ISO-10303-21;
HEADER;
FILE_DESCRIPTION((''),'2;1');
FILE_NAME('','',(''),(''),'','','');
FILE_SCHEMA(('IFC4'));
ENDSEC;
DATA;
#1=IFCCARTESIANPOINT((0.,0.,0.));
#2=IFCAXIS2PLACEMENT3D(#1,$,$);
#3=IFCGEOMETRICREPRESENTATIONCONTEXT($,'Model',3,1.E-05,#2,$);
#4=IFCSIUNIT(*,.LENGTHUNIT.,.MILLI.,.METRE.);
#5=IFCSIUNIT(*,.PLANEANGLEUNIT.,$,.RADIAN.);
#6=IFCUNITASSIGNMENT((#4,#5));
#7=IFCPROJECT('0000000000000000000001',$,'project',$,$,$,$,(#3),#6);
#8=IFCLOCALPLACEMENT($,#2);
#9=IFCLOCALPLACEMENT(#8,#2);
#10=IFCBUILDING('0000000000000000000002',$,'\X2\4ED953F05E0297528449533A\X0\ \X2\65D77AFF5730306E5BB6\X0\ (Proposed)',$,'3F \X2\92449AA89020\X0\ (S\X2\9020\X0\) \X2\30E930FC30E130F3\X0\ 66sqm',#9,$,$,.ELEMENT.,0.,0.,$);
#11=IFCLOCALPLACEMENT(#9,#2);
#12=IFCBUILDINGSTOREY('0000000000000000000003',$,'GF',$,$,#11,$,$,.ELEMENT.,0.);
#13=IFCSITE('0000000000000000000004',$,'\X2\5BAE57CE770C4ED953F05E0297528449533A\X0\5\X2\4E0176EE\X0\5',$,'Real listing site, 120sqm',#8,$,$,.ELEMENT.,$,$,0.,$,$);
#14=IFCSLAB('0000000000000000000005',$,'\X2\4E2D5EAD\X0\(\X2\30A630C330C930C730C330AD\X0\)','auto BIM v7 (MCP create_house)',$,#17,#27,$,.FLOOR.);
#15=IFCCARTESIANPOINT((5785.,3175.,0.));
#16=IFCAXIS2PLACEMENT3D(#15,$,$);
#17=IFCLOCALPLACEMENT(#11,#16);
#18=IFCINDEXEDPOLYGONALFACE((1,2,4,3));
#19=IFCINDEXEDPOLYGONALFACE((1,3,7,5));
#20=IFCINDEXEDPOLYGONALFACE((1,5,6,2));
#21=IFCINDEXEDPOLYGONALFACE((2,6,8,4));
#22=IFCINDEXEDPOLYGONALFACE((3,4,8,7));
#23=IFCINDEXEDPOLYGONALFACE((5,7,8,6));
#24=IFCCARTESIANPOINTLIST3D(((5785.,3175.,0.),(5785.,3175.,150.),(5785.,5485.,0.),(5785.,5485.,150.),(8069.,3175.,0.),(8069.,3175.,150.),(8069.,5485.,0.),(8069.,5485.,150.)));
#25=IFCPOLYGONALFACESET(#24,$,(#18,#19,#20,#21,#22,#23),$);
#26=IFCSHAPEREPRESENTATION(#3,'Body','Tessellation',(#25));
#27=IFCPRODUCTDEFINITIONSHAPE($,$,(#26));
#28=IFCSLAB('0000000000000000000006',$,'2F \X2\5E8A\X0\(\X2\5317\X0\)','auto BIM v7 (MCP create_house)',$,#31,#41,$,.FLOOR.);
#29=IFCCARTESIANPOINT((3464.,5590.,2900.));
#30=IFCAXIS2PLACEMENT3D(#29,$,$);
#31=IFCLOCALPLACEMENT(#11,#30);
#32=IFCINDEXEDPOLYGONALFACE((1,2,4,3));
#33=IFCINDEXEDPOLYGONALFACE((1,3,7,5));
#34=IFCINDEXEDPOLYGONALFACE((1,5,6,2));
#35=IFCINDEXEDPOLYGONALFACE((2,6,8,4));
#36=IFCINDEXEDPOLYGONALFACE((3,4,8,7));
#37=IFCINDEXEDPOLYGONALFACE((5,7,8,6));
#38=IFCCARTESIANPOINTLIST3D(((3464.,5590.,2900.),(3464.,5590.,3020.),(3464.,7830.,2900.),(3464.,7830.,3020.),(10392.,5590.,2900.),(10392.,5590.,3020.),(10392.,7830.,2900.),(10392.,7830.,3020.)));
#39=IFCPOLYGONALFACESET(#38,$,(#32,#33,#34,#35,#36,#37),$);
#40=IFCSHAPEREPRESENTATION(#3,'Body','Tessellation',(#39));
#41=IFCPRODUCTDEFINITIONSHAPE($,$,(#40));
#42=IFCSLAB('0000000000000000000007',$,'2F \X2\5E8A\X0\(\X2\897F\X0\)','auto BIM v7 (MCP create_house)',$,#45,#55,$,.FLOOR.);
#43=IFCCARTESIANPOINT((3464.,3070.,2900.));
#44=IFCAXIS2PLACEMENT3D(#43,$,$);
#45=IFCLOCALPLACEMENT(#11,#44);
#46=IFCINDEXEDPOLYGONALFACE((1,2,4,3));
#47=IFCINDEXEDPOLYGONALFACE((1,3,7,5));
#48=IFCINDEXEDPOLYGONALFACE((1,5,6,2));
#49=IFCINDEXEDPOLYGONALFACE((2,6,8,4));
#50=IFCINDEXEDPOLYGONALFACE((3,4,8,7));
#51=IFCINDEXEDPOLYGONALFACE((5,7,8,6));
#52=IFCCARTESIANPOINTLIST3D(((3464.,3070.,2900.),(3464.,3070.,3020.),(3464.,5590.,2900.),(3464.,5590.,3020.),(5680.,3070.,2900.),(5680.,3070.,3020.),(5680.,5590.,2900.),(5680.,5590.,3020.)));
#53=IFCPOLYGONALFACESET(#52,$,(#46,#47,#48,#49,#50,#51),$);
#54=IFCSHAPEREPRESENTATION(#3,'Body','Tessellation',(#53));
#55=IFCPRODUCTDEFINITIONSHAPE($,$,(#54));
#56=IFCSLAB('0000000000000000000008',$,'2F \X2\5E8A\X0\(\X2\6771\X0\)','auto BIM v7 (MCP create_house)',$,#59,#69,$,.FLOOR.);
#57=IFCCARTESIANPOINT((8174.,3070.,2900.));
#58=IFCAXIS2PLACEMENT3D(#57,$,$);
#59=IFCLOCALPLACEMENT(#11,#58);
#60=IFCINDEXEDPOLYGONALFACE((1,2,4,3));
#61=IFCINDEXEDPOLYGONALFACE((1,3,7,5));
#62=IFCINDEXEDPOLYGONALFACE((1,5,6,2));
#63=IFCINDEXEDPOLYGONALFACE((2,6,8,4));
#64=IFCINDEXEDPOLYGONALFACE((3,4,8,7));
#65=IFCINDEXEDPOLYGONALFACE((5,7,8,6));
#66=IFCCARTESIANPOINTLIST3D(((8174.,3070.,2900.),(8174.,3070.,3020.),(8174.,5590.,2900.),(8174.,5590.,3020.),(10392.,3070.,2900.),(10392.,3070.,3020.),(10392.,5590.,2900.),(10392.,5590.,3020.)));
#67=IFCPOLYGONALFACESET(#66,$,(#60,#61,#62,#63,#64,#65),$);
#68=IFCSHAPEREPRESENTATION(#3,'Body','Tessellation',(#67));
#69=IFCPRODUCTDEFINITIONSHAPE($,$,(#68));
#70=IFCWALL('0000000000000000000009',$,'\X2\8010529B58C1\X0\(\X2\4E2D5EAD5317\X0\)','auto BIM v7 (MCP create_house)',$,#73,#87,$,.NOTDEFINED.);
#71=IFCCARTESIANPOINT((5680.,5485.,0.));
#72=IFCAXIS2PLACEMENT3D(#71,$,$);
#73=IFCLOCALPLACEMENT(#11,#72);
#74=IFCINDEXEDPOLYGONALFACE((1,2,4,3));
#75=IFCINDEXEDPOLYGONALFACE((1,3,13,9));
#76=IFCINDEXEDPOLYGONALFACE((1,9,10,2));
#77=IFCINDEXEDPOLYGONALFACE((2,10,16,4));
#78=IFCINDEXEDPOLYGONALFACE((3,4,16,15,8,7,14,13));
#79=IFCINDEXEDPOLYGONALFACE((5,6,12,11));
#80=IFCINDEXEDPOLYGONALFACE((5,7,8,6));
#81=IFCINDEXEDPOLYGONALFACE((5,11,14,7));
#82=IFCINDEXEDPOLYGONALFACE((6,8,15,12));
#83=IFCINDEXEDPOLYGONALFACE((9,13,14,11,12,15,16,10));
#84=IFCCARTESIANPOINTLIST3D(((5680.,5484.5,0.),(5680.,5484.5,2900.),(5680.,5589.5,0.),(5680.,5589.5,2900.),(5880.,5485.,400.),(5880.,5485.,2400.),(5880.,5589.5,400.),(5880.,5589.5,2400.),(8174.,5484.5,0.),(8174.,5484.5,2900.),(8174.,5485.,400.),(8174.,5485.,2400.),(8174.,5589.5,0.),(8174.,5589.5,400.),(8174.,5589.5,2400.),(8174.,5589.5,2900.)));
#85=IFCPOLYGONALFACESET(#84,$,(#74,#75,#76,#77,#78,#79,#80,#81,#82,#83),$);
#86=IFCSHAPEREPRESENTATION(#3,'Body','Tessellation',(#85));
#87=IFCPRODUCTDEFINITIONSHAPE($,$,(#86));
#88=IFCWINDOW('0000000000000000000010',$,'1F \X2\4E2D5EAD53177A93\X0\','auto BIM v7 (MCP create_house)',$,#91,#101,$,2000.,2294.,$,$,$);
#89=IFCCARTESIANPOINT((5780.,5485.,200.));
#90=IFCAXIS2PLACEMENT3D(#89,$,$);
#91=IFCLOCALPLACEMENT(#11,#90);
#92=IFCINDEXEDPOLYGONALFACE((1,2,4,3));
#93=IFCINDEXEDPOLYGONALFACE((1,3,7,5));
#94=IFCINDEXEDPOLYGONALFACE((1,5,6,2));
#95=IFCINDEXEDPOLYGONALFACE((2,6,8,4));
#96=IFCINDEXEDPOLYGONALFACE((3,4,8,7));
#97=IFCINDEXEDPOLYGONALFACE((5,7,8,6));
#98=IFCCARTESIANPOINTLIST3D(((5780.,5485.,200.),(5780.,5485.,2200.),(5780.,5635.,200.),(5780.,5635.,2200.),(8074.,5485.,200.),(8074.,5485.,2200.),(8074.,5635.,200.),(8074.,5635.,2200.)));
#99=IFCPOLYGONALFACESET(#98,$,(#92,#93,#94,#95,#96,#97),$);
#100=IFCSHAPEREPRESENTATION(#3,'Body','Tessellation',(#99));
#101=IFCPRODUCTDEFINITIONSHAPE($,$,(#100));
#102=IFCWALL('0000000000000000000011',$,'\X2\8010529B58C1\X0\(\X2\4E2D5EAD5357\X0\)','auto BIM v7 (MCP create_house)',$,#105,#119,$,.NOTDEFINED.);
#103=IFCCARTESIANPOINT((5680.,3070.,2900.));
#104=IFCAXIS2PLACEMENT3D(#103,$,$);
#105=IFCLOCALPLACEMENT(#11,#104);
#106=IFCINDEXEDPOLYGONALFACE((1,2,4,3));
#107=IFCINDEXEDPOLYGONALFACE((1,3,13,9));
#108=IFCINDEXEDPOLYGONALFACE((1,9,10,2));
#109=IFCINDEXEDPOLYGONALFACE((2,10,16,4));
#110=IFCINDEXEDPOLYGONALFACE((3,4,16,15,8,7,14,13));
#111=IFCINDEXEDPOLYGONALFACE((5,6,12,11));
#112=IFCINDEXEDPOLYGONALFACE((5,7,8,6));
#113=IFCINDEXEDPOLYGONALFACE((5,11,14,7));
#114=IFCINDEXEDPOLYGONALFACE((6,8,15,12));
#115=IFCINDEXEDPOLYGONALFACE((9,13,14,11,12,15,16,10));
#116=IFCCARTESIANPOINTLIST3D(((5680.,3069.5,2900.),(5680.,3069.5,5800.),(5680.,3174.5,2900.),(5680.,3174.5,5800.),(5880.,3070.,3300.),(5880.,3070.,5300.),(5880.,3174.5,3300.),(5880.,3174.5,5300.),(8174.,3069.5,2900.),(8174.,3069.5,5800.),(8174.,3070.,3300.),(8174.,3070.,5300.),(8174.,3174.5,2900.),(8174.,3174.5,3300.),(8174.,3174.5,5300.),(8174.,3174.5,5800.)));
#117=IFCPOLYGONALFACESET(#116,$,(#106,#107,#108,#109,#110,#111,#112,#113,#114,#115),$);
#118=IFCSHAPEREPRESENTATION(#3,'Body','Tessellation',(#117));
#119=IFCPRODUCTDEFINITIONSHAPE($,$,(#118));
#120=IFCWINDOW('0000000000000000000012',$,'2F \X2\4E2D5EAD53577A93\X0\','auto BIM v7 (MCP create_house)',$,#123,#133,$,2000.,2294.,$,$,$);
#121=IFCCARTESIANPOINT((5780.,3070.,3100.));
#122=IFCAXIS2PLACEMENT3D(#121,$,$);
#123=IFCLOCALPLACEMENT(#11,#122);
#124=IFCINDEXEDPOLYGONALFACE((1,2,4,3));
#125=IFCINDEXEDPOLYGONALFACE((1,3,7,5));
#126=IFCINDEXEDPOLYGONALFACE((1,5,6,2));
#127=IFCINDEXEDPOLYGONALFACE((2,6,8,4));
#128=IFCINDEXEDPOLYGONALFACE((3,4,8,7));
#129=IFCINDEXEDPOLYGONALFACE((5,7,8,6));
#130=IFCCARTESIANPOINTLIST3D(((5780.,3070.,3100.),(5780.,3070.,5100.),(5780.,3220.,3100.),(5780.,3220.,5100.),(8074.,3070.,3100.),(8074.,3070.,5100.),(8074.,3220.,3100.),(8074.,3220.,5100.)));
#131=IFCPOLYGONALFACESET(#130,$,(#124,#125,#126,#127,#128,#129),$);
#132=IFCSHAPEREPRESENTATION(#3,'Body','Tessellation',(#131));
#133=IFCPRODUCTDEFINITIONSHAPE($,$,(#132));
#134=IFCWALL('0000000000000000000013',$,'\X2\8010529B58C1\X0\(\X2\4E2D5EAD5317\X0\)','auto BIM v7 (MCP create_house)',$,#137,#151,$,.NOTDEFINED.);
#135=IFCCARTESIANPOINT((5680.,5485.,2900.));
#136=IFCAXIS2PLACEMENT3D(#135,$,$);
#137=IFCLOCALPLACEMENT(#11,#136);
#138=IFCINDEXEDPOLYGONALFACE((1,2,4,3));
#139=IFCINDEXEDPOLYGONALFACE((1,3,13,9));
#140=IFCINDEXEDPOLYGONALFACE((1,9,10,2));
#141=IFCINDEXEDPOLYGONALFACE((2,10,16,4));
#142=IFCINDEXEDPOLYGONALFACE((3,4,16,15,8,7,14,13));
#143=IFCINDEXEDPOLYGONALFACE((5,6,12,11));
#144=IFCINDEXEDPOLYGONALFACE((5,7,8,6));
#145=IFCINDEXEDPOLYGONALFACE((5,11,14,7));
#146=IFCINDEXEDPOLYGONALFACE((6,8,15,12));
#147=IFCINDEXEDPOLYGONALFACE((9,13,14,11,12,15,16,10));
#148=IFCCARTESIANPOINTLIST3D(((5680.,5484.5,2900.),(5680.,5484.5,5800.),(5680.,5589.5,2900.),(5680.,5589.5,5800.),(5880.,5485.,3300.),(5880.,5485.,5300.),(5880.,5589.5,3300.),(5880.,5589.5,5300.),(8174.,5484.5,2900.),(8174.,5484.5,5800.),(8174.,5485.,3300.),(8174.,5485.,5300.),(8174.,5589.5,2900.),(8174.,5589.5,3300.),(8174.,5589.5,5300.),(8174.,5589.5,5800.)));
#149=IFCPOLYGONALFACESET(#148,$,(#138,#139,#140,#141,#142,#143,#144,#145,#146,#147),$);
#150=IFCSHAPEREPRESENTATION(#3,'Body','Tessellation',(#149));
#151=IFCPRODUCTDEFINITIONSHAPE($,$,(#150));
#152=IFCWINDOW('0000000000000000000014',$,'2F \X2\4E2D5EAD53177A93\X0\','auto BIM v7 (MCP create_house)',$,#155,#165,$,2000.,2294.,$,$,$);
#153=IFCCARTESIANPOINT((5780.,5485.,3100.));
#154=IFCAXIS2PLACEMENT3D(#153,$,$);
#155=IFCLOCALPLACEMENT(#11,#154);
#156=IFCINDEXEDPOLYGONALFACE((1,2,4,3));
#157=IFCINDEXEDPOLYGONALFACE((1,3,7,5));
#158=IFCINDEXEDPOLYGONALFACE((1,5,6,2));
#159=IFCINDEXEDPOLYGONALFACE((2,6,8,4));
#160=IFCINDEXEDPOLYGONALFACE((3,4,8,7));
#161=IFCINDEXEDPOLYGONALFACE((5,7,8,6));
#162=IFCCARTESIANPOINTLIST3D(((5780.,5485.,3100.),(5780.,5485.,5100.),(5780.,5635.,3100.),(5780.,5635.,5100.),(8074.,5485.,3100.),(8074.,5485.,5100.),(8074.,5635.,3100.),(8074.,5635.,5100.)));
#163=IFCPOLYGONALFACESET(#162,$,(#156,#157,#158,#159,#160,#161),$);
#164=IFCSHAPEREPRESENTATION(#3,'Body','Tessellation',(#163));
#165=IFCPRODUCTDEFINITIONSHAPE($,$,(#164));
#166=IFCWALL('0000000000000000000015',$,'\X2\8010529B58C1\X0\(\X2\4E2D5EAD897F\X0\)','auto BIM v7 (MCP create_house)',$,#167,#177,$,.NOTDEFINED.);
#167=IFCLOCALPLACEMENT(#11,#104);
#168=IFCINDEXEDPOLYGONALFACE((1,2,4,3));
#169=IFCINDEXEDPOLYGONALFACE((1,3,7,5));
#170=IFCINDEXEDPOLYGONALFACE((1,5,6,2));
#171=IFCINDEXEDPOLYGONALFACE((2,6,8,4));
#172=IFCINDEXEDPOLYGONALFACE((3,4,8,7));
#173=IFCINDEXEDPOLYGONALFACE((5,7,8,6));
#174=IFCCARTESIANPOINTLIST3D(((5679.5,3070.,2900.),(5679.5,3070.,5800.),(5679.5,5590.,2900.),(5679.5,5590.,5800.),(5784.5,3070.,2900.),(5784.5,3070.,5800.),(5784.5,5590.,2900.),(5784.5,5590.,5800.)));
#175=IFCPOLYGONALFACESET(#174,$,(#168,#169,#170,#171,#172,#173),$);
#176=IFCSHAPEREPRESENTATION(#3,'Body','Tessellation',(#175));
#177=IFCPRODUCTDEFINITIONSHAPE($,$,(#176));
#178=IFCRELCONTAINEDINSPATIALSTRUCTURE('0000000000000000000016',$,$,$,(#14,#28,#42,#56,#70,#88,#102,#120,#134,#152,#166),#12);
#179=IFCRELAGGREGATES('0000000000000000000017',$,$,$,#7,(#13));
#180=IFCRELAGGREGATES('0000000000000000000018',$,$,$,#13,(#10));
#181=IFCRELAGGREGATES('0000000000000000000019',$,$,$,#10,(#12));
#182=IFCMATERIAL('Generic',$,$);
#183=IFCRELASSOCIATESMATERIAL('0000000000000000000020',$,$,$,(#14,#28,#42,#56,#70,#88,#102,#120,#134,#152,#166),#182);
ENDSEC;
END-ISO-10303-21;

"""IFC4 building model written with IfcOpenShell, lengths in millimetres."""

from ifc_helpers import new_model, si_unit, frame, frame_2d, origin, place, context, project, spatial, rectangle, extrude, material, element, fill, save


model = new_model("IFC4")

# Units and contexts
model_context = context("Model", 3, precision=1e-05, world=origin())
ifc_project = project(units=[si_unit("LENGTHUNIT", "METRE", prefix="MILLI"), si_unit("PLANEANGLEUNIT", "RADIAN")], contexts=[model_context])

# Site, building, storey
site_placement = place(None, origin())
site = spatial("IfcSite", under=ifc_project, at=site_placement, Name="宮城県仙台市青葉区5丁目5", ObjectType="Real listing site, 120sqm", CompositionType="ELEMENT", RefElevation=0.0)
building_placement = place(site_placement, origin())
building = spatial("IfcBuilding", under=site, at=building_placement, Name="仙台市青葉区 旗竿地の家 (Proposed)", ObjectType="3F 鉄骨造 (S造) ラーメン 66sqm", CompositionType="ELEMENT", ElevationOfRefHeight=0.0, ElevationOfTerrain=0.0)
storey_placement = place(building_placement, origin())
storey = spatial("IfcBuildingStorey", under=building, at=storey_placement, Name="GF", CompositionType="ELEMENT", Elevation=0.0)

# Slabs
ifc_material = material(Name="Generic")
slab_1_placement = place(storey_placement, frame((5785.0, 3175.0, 0.0)))
element("IfcSlab", 1, at=slab_1_placement, inside=storey, material=ifc_material, Name="中庭(ウッドデッキ)", Description="auto BIM v7 (MCP create_house)", PredefinedType="FLOOR", context=model_context, shape_type="SweptSolid", body=[
    extrude(rectangle(XDim=2284.0, YDim=2310.0, at=frame_2d((1142.0, 1155.0))), frame((5785.0, 3175.0, 0.0)), (0.0, 0.0, 1.0), 150.0),
])
slab_2_placement = place(storey_placement, frame((3464.0, 5590.0, 2900.0)))
element("IfcSlab", 2, at=slab_2_placement, inside=storey, material=ifc_material, Name="2F 床(北)", Description="auto BIM v7 (MCP create_house)", PredefinedType="FLOOR", context=model_context, shape_type="SweptSolid", body=[
    extrude(rectangle(XDim=6928.0, YDim=2240.0, at=frame_2d((3464.0, 1120.0))), frame((3464.0, 5590.0, 2900.0)), (0.0, 0.0, 1.0), 120.0),
])
slab_3_placement = place(storey_placement, frame((3464.0, 3070.0, 2900.0)))
element("IfcSlab", 3, at=slab_3_placement, inside=storey, material=ifc_material, Name="2F 床(西)", Description="auto BIM v7 (MCP create_house)", PredefinedType="FLOOR", context=model_context, shape_type="SweptSolid", body=[
    extrude(rectangle(XDim=2216.0, YDim=2520.0, at=frame_2d((1108.0, 1260.0))), frame((3464.0, 3070.0, 2900.0)), (0.0, 0.0, 1.0), 120.0),
])
slab_4_placement = place(storey_placement, frame((8174.0, 3070.0, 2900.0)))
element("IfcSlab", 4, at=slab_4_placement, inside=storey, material=ifc_material, Name="2F 床(東)", Description="auto BIM v7 (MCP create_house)", PredefinedType="FLOOR", context=model_context, shape_type="SweptSolid", body=[
    extrude(rectangle(XDim=2218.0, YDim=2520.0, at=frame_2d((1109.0, 1260.0))), frame((8174.0, 3070.0, 2900.0)), (0.0, 0.0, 1.0), 120.0),
])

# Wall, opening, window
wall_1_placement = place(storey_placement, frame((5680.0, 5485.0, 0.0)))
wall_1 = element("IfcWall", 5, at=wall_1_placement, inside=storey, material=ifc_material, Name="耐力壁(中庭北)", Description="auto BIM v7 (MCP create_house)", PredefinedType="NOTDEFINED", context=model_context, shape_type="SweptSolid", body=[
    extrude(rectangle(XDim=2494.0, YDim=105.0, at=frame_2d((1247.0, 52.0))), frame((5680.0, 5485.0, 0.0)), (0.0, 0.0, 1.0), 2900.0),
])
opening_1_placement = place(storey_placement, frame((5780.0, 5485.0, 200.0)))
opening_1 = element("IfcOpeningElement", 6, at=opening_1_placement, cuts=wall_1, PredefinedType="NOTDEFINED", context=model_context, shape_type="SweptSolid", body=[
    extrude(rectangle(XDim=2294.0, YDim=150.0, at=frame_2d((1147.0, 75.0))), frame((5780.0, 5485.0, 200.0)), (0.0, 0.0, 1.0), 2000.0),
])
window_1_placement = place(storey_placement, frame((5780.0, 5485.0, 200.0)))
window_1 = element("IfcWindow", 7, at=window_1_placement, inside=storey, material=ifc_material, Name="1F 中庭北窓", Description="auto BIM v7 (MCP create_house)", OverallHeight=2000.0, OverallWidth=2294.0, context=model_context, shape_type="SweptSolid", body=[
    extrude(rectangle(XDim=2294.0, YDim=150.0, at=frame_2d((1147.0, 75.0))), frame((5780.0, 5485.0, 200.0)), (0.0, 0.0, 1.0), 2000.0),
])
fill(opening_1, window_1)

# Walls, openings, windows
wall_2_placement = place(storey_placement, frame((5680.0, 3070.0, 2900.0)))
wall_2 = element("IfcWall", 8, at=wall_2_placement, inside=storey, material=ifc_material, Name="耐力壁(中庭南)", Description="auto BIM v7 (MCP create_house)", PredefinedType="NOTDEFINED", context=model_context, shape_type="SweptSolid", body=[
    extrude(rectangle(XDim=2494.0, YDim=105.0, at=frame_2d((1247.0, 52.0))), frame((5680.0, 3070.0, 2900.0)), (0.0, 0.0, 1.0), 2900.0),
])
opening_2_placement = place(storey_placement, frame((5780.0, 3070.0, 3100.0)))
opening_2 = element("IfcOpeningElement", 9, at=opening_2_placement, cuts=wall_2, PredefinedType="NOTDEFINED", context=model_context, shape_type="SweptSolid", body=[
    extrude(rectangle(XDim=2294.0, YDim=150.0, at=frame_2d((1147.0, 75.0))), frame((5780.0, 3070.0, 3100.0)), (0.0, 0.0, 1.0), 2000.0),
])
window_2_placement = place(storey_placement, frame((5780.0, 3070.0, 3100.0)))
window_2 = element("IfcWindow", 10, at=window_2_placement, inside=storey, material=ifc_material, Name="2F 中庭南窓", Description="auto BIM v7 (MCP create_house)", OverallHeight=2000.0, OverallWidth=2294.0, context=model_context, shape_type="SweptSolid", body=[
    extrude(rectangle(XDim=2294.0, YDim=150.0, at=frame_2d((1147.0, 75.0))), frame((5780.0, 3070.0, 3100.0)), (0.0, 0.0, 1.0), 2000.0),
])
fill(opening_2, window_2)
wall_3_placement = place(storey_placement, frame((5680.0, 5485.0, 2900.0)))
wall_3 = element("IfcWall", 11, at=wall_3_placement, inside=storey, material=ifc_material, Name="耐力壁(中庭北)", Description="auto BIM v7 (MCP create_house)", PredefinedType="NOTDEFINED", context=model_context, shape_type="SweptSolid", body=[
    extrude(rectangle(XDim=2494.0, YDim=105.0, at=frame_2d((1247.0, 52.0))), frame((5680.0, 5485.0, 2900.0)), (0.0, 0.0, 1.0), 2900.0),
])
opening_3_placement = place(storey_placement, frame((5780.0, 5485.0, 3100.0)))
opening_3 = element("IfcOpeningElement", 12, at=opening_3_placement, cuts=wall_3, PredefinedType="NOTDEFINED", context=model_context, shape_type="SweptSolid", body=[
    extrude(rectangle(XDim=2294.0, YDim=150.0, at=frame_2d((1147.0, 75.0))), frame((5780.0, 5485.0, 3100.0)), (0.0, 0.0, 1.0), 2000.0),
])
window_3_placement = place(storey_placement, frame((5780.0, 5485.0, 3100.0)))
window_3 = element("IfcWindow", 13, at=window_3_placement, inside=storey, material=ifc_material, Name="2F 中庭北窓", Description="auto BIM v7 (MCP create_house)", OverallHeight=2000.0, OverallWidth=2294.0, context=model_context, shape_type="SweptSolid", body=[
    extrude(rectangle(XDim=2294.0, YDim=150.0, at=frame_2d((1147.0, 75.0))), frame((5780.0, 5485.0, 3100.0)), (0.0, 0.0, 1.0), 2000.0),
])
fill(opening_3, window_3)

# Wall
wall_4_placement = place(storey_placement, frame((5680.0, 3070.0, 2900.0)))
element("IfcWall", 14, at=wall_4_placement, inside=storey, material=ifc_material, Name="耐力壁(中庭西)", Description="auto BIM v7 (MCP create_house)", PredefinedType="NOTDEFINED", context=model_context, shape_type="SweptSolid", body=[
    extrude(rectangle(XDim=105.0, YDim=2520.0, at=frame_2d((52.0, 1260.0))), frame((5680.0, 3070.0, 2900.0)), (0.0, 0.0, 1.0), 2900.0),
])

save(model, "model.ifc")
